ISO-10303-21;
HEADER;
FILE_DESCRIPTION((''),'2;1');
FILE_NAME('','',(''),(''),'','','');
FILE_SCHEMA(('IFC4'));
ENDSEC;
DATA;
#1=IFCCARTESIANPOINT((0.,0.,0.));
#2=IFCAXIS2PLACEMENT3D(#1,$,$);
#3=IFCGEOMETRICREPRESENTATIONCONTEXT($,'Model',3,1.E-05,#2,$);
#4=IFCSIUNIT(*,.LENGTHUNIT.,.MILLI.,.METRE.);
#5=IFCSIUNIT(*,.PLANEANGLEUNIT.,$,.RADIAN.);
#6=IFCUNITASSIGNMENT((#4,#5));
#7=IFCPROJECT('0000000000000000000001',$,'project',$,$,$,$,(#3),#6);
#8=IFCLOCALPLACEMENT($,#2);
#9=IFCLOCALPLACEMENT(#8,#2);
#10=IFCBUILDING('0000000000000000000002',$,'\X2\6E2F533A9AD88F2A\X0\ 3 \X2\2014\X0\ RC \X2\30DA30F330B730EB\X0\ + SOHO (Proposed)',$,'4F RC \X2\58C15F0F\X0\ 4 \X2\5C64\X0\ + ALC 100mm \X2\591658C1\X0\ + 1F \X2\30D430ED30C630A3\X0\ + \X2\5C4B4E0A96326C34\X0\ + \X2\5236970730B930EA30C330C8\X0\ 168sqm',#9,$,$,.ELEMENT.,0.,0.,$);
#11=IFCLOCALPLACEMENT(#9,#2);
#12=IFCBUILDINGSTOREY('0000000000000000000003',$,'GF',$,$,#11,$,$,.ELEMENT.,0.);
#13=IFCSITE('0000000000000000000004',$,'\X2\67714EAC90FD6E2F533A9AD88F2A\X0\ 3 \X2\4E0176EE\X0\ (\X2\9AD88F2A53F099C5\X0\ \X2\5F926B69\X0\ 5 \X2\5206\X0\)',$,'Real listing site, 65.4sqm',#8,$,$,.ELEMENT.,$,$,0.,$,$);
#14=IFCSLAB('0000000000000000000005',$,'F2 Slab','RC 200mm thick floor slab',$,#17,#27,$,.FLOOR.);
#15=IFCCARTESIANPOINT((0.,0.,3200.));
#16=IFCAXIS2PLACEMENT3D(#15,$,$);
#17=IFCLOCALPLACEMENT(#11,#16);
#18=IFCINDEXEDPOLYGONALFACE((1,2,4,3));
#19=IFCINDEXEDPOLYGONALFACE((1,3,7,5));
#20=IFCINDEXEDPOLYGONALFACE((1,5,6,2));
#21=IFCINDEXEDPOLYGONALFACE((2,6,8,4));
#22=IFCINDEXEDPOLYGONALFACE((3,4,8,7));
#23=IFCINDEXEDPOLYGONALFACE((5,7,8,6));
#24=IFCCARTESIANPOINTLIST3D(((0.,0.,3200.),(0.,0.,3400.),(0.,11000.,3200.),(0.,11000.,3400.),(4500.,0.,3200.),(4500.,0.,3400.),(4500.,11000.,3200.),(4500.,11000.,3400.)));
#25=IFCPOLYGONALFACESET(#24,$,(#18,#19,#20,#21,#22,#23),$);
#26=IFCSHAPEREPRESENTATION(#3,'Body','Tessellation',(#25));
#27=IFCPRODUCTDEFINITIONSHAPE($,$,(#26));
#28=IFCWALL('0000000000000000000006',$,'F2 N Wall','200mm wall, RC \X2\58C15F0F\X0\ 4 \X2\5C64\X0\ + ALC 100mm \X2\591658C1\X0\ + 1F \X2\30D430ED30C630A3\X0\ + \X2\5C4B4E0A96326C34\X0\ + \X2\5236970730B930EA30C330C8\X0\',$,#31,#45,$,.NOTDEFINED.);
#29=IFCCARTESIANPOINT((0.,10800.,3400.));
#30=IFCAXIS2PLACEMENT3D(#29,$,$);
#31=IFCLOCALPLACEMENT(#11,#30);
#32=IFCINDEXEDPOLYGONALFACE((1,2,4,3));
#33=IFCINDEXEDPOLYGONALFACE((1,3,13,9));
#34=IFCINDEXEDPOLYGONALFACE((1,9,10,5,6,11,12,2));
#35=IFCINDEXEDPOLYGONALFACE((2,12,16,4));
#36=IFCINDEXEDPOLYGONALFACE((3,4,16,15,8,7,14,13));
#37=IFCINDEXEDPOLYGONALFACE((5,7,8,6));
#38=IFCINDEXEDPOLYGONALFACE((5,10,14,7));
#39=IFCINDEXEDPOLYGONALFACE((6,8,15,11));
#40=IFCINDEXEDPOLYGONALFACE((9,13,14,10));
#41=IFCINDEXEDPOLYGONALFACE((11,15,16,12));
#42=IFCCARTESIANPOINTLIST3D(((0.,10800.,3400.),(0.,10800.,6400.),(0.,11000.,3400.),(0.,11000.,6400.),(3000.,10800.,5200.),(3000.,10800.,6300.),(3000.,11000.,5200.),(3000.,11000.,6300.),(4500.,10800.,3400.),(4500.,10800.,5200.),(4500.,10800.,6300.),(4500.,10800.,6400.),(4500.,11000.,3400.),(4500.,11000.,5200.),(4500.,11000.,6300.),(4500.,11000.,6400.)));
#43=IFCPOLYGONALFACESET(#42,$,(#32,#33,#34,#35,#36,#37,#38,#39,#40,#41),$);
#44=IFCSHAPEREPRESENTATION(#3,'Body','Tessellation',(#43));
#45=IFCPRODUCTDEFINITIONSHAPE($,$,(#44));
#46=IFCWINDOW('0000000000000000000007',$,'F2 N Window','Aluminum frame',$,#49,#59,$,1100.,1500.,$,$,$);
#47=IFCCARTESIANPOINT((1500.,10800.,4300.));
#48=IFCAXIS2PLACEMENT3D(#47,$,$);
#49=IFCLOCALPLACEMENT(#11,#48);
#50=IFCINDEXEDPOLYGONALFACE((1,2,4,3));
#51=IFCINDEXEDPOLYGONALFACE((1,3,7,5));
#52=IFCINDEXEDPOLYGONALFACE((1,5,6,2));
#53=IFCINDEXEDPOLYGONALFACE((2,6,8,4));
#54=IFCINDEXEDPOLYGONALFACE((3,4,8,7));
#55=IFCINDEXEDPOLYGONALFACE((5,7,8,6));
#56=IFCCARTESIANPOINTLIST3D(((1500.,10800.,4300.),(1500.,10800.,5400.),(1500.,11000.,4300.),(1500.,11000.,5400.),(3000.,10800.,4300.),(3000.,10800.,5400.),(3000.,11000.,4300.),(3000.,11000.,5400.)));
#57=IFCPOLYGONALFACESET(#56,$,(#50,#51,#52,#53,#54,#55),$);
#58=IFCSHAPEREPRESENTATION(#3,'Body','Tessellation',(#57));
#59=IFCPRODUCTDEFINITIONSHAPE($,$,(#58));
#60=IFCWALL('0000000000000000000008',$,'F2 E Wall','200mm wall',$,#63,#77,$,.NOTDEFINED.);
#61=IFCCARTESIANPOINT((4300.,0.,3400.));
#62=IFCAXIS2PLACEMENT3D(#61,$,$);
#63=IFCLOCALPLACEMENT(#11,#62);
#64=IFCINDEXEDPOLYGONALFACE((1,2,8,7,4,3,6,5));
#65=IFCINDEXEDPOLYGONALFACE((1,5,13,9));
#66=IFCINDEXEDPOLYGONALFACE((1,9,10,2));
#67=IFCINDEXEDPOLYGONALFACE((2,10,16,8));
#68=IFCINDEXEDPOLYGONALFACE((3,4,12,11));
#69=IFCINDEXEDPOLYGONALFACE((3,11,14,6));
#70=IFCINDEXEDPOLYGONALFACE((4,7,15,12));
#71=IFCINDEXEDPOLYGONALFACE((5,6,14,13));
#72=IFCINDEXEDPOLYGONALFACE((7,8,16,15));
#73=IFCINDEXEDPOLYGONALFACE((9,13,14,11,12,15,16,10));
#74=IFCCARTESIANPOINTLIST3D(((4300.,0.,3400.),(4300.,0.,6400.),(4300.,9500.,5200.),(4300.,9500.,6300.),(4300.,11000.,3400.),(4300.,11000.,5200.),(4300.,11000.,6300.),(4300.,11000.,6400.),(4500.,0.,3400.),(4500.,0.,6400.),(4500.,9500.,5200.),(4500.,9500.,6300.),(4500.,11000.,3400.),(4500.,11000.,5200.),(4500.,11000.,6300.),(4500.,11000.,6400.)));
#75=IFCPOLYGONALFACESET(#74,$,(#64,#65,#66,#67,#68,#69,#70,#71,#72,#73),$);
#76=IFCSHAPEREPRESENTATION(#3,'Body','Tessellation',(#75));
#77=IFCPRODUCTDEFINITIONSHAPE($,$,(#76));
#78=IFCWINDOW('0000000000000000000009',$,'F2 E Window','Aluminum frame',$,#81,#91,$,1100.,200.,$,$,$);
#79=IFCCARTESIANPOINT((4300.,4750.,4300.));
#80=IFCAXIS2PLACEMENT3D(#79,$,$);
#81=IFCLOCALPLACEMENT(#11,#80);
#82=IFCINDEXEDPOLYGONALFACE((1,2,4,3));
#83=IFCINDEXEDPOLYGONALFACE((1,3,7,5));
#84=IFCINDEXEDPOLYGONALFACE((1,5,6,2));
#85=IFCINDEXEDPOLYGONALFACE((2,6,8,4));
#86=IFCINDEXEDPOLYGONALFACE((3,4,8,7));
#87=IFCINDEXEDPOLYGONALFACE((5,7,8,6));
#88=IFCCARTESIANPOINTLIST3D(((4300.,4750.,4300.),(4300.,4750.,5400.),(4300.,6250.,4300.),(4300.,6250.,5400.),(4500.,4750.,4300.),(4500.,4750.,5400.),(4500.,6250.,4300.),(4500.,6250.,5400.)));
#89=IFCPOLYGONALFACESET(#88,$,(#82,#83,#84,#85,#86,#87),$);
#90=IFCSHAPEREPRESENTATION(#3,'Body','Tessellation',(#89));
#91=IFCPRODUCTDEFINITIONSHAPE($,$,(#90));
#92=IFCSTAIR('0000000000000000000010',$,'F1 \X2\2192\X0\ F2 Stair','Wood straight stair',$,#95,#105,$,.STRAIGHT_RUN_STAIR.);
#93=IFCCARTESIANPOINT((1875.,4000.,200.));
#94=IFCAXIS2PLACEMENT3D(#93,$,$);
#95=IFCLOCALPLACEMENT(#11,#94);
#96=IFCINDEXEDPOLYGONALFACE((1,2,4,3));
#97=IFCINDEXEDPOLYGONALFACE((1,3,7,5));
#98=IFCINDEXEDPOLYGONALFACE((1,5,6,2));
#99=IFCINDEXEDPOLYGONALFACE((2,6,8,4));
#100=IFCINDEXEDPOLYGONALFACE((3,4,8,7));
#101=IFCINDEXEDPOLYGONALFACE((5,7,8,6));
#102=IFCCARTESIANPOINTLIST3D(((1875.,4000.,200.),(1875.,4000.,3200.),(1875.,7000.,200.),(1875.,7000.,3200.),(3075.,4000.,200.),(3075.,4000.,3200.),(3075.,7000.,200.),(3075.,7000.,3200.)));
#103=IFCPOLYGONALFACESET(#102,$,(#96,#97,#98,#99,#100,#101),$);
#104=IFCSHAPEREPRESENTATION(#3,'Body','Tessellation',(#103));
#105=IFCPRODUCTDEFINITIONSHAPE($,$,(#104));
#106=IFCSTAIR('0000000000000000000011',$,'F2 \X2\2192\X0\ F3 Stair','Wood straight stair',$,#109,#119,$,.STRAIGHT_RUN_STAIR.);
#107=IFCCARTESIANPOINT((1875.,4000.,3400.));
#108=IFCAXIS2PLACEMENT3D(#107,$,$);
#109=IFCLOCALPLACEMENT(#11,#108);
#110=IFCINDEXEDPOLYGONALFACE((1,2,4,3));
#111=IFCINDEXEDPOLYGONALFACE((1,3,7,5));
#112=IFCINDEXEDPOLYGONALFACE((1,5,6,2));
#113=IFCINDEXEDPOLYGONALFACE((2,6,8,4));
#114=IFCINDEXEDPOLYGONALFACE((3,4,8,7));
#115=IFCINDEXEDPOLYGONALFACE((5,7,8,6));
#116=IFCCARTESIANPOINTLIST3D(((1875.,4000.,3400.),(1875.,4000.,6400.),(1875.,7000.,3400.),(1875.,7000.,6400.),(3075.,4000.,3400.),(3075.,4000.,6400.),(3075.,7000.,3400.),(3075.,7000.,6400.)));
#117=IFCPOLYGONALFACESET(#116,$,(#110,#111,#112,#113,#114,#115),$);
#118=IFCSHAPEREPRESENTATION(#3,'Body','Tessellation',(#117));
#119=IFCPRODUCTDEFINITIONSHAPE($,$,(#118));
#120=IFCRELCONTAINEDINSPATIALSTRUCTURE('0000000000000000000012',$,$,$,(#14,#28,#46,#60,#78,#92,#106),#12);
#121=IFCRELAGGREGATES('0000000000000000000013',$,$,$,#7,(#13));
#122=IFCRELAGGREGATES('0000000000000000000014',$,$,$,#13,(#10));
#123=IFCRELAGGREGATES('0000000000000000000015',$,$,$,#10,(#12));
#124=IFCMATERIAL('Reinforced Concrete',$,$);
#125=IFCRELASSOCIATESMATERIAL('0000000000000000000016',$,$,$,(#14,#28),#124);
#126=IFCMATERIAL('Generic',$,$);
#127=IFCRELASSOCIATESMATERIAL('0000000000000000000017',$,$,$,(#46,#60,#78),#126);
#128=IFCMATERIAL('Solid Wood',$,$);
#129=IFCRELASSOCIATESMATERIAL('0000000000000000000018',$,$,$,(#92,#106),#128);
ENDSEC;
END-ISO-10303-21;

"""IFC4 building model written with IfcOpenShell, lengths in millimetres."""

from ifc_helpers import new_model, si_unit, frame, frame_2d, origin, place, context, project, spatial, rectangle, extrude, material, element, fill, save


model = new_model("IFC4")

# Units and contexts
model_context = context("Model", 3, precision=1e-05, world=origin())
ifc_project = project(units=[si_unit("LENGTHUNIT", "METRE", prefix="MILLI"), si_unit("PLANEANGLEUNIT", "RADIAN")], contexts=[model_context])

# Site, building, storey
site_placement = place(None, origin())
site = spatial("IfcSite", under=ifc_project, at=site_placement, Name="東京都港区高輪 3 丁目 (高輪台駅 徒歩 5 分)", ObjectType="Real listing site, 65.4sqm", CompositionType="ELEMENT", RefElevation=0.0)
building_placement = place(site_placement, origin())
building = spatial("IfcBuilding", under=site, at=building_placement, Name="港区高輪 3 — RC ペンシル + SOHO (Proposed)", ObjectType="4F RC 壁式 4 層 + ALC 100mm 外壁 + 1F ピロティ + 屋上防水 + 制震スリット 168sqm", CompositionType="ELEMENT", ElevationOfRefHeight=0.0, ElevationOfTerrain=0.0)
storey_placement = place(building_placement, origin())
storey = spatial("IfcBuildingStorey", under=building, at=storey_placement, Name="GF", CompositionType="ELEMENT", Elevation=0.0)

# Slab
ifc_material_1 = material(Name="Reinforced Concrete")
slab_1_placement = place(storey_placement, frame((0.0, 0.0, 3200.0)))
element("IfcSlab", 1, at=slab_1_placement, inside=storey, material=ifc_material_1, Name="F2 Slab", Description="RC 200mm thick floor slab", PredefinedType="FLOOR", context=model_context, shape_type="SweptSolid", body=[
    extrude(rectangle(XDim=4500.0, YDim=11000.0, at=frame_2d((2250.0, 5500.0))), frame((0.0, 0.0, 3200.0)), (0.0, 0.0, 1.0), 200.0),
])

# Shared definitions
ifc_material_2 = material(Name="Generic")

# Shared definitions
ifc_material_3 = material(Name="Solid Wood")

# Walls, openings, windows
wall_1_placement = place(storey_placement, frame((0.0, 10800.0, 3400.0)))
wall_1 = element("IfcWall", 2, at=wall_1_placement, inside=storey, material=ifc_material_1, Name="F2 N Wall", Description="200mm wall, RC 壁式 4 層 + ALC 100mm 外壁 + 1F ピロティ + 屋上防水 + 制震スリット", PredefinedType="NOTDEFINED", context=model_context, shape_type="SweptSolid", body=[
    extrude(rectangle(XDim=4500.0, YDim=200.0, at=frame_2d((2250.0, 100.0))), frame((0.0, 10800.0, 3400.0)), (0.0, 0.0, 1.0), 3000.0),
])
opening_1_placement = place(storey_placement, frame((1500.0, 10800.0, 4300.0)))
opening_1 = element("IfcOpeningElement", 3, at=opening_1_placement, cuts=wall_1, PredefinedType="NOTDEFINED", context=model_context, shape_type="SweptSolid", body=[
    extrude(rectangle(XDim=1500.0, YDim=200.0, at=frame_2d((750.0, 100.0))), frame((1500.0, 10800.0, 4300.0)), (0.0, 0.0, 1.0), 1100.0),
])
window_1_placement = place(storey_placement, frame((1500.0, 10800.0, 4300.0)))
window_1 = element("IfcWindow", 4, at=window_1_placement, inside=storey, material=ifc_material_2, Name="F2 N Window", Description="Aluminum frame", OverallHeight=1100.0, OverallWidth=1500.0, context=model_context, shape_type="SweptSolid", body=[
    extrude(rectangle(XDim=1500.0, YDim=200.0, at=frame_2d((750.0, 100.0))), frame((1500.0, 10800.0, 4300.0)), (0.0, 0.0, 1.0), 1100.0),
])
fill(opening_1, window_1)
wall_2_placement = place(storey_placement, frame((4300.0, 0.0, 3400.0)))
wall_2 = element("IfcWall", 5, at=wall_2_placement, inside=storey, material=ifc_material_2, Name="F2 E Wall", Description="200mm wall", PredefinedType="NOTDEFINED", context=model_context, shape_type="SweptSolid", body=[
    extrude(rectangle(XDim=200.0, YDim=11000.0, at=frame_2d((100.0, 5500.0))), frame((4300.0, 0.0, 3400.0)), (0.0, 0.0, 1.0), 3000.0),
])
opening_2_placement = place(storey_placement, frame((4300.0, 4750.0, 4300.0)))
opening_2 = element("IfcOpeningElement", 6, at=opening_2_placement, cuts=wall_2, PredefinedType="NOTDEFINED", context=model_context, shape_type="SweptSolid", body=[
    extrude(rectangle(XDim=200.0, YDim=1500.0, at=frame_2d((100.0, 750.0))), frame((4300.0, 4750.0, 4300.0)), (0.0, 0.0, 1.0), 1100.0),
])
window_2_placement = place(storey_placement, frame((4300.0, 4750.0, 4300.0)))
window_2 = element("IfcWindow", 7, at=window_2_placement, inside=storey, material=ifc_material_2, Name="F2 E Window", Description="Aluminum frame", OverallHeight=1100.0, OverallWidth=200.0, context=model_context, shape_type="SweptSolid", body=[
    extrude(rectangle(XDim=200.0, YDim=1500.0, at=frame_2d((100.0, 750.0))), frame((4300.0, 4750.0, 4300.0)), (0.0, 0.0, 1.0), 1100.0),
])
fill(opening_2, window_2)

# Stairs
stair_1_placement = place(storey_placement, frame((1875.0, 4000.0, 200.0)))
element("IfcStair", 8, at=stair_1_placement, inside=storey, material=ifc_material_3, Name="F1 → F2 Stair", Description="Wood straight stair", PredefinedType="STRAIGHT_RUN_STAIR", context=model_context, shape_type="SweptSolid", body=[
    extrude(rectangle(XDim=1200.0, YDim=3000.0, at=frame_2d((600.0, 1500.0))), frame((1875.0, 4000.0, 200.0)), (0.0, 0.0, 1.0), 3000.0),
])
stair_2_placement = place(storey_placement, frame((1875.0, 4000.0, 3400.0)))
element("IfcStair", 9, at=stair_2_placement, inside=storey, material=ifc_material_3, Name="F2 → F3 Stair", Description="Wood straight stair", PredefinedType="STRAIGHT_RUN_STAIR", context=model_context, shape_type="SweptSolid", body=[
    extrude(rectangle(XDim=1200.0, YDim=3000.0, at=frame_2d((600.0, 1500.0))), frame((1875.0, 4000.0, 3400.0)), (0.0, 0.0, 1.0), 3000.0),
])

save(model, "model.ifc")
